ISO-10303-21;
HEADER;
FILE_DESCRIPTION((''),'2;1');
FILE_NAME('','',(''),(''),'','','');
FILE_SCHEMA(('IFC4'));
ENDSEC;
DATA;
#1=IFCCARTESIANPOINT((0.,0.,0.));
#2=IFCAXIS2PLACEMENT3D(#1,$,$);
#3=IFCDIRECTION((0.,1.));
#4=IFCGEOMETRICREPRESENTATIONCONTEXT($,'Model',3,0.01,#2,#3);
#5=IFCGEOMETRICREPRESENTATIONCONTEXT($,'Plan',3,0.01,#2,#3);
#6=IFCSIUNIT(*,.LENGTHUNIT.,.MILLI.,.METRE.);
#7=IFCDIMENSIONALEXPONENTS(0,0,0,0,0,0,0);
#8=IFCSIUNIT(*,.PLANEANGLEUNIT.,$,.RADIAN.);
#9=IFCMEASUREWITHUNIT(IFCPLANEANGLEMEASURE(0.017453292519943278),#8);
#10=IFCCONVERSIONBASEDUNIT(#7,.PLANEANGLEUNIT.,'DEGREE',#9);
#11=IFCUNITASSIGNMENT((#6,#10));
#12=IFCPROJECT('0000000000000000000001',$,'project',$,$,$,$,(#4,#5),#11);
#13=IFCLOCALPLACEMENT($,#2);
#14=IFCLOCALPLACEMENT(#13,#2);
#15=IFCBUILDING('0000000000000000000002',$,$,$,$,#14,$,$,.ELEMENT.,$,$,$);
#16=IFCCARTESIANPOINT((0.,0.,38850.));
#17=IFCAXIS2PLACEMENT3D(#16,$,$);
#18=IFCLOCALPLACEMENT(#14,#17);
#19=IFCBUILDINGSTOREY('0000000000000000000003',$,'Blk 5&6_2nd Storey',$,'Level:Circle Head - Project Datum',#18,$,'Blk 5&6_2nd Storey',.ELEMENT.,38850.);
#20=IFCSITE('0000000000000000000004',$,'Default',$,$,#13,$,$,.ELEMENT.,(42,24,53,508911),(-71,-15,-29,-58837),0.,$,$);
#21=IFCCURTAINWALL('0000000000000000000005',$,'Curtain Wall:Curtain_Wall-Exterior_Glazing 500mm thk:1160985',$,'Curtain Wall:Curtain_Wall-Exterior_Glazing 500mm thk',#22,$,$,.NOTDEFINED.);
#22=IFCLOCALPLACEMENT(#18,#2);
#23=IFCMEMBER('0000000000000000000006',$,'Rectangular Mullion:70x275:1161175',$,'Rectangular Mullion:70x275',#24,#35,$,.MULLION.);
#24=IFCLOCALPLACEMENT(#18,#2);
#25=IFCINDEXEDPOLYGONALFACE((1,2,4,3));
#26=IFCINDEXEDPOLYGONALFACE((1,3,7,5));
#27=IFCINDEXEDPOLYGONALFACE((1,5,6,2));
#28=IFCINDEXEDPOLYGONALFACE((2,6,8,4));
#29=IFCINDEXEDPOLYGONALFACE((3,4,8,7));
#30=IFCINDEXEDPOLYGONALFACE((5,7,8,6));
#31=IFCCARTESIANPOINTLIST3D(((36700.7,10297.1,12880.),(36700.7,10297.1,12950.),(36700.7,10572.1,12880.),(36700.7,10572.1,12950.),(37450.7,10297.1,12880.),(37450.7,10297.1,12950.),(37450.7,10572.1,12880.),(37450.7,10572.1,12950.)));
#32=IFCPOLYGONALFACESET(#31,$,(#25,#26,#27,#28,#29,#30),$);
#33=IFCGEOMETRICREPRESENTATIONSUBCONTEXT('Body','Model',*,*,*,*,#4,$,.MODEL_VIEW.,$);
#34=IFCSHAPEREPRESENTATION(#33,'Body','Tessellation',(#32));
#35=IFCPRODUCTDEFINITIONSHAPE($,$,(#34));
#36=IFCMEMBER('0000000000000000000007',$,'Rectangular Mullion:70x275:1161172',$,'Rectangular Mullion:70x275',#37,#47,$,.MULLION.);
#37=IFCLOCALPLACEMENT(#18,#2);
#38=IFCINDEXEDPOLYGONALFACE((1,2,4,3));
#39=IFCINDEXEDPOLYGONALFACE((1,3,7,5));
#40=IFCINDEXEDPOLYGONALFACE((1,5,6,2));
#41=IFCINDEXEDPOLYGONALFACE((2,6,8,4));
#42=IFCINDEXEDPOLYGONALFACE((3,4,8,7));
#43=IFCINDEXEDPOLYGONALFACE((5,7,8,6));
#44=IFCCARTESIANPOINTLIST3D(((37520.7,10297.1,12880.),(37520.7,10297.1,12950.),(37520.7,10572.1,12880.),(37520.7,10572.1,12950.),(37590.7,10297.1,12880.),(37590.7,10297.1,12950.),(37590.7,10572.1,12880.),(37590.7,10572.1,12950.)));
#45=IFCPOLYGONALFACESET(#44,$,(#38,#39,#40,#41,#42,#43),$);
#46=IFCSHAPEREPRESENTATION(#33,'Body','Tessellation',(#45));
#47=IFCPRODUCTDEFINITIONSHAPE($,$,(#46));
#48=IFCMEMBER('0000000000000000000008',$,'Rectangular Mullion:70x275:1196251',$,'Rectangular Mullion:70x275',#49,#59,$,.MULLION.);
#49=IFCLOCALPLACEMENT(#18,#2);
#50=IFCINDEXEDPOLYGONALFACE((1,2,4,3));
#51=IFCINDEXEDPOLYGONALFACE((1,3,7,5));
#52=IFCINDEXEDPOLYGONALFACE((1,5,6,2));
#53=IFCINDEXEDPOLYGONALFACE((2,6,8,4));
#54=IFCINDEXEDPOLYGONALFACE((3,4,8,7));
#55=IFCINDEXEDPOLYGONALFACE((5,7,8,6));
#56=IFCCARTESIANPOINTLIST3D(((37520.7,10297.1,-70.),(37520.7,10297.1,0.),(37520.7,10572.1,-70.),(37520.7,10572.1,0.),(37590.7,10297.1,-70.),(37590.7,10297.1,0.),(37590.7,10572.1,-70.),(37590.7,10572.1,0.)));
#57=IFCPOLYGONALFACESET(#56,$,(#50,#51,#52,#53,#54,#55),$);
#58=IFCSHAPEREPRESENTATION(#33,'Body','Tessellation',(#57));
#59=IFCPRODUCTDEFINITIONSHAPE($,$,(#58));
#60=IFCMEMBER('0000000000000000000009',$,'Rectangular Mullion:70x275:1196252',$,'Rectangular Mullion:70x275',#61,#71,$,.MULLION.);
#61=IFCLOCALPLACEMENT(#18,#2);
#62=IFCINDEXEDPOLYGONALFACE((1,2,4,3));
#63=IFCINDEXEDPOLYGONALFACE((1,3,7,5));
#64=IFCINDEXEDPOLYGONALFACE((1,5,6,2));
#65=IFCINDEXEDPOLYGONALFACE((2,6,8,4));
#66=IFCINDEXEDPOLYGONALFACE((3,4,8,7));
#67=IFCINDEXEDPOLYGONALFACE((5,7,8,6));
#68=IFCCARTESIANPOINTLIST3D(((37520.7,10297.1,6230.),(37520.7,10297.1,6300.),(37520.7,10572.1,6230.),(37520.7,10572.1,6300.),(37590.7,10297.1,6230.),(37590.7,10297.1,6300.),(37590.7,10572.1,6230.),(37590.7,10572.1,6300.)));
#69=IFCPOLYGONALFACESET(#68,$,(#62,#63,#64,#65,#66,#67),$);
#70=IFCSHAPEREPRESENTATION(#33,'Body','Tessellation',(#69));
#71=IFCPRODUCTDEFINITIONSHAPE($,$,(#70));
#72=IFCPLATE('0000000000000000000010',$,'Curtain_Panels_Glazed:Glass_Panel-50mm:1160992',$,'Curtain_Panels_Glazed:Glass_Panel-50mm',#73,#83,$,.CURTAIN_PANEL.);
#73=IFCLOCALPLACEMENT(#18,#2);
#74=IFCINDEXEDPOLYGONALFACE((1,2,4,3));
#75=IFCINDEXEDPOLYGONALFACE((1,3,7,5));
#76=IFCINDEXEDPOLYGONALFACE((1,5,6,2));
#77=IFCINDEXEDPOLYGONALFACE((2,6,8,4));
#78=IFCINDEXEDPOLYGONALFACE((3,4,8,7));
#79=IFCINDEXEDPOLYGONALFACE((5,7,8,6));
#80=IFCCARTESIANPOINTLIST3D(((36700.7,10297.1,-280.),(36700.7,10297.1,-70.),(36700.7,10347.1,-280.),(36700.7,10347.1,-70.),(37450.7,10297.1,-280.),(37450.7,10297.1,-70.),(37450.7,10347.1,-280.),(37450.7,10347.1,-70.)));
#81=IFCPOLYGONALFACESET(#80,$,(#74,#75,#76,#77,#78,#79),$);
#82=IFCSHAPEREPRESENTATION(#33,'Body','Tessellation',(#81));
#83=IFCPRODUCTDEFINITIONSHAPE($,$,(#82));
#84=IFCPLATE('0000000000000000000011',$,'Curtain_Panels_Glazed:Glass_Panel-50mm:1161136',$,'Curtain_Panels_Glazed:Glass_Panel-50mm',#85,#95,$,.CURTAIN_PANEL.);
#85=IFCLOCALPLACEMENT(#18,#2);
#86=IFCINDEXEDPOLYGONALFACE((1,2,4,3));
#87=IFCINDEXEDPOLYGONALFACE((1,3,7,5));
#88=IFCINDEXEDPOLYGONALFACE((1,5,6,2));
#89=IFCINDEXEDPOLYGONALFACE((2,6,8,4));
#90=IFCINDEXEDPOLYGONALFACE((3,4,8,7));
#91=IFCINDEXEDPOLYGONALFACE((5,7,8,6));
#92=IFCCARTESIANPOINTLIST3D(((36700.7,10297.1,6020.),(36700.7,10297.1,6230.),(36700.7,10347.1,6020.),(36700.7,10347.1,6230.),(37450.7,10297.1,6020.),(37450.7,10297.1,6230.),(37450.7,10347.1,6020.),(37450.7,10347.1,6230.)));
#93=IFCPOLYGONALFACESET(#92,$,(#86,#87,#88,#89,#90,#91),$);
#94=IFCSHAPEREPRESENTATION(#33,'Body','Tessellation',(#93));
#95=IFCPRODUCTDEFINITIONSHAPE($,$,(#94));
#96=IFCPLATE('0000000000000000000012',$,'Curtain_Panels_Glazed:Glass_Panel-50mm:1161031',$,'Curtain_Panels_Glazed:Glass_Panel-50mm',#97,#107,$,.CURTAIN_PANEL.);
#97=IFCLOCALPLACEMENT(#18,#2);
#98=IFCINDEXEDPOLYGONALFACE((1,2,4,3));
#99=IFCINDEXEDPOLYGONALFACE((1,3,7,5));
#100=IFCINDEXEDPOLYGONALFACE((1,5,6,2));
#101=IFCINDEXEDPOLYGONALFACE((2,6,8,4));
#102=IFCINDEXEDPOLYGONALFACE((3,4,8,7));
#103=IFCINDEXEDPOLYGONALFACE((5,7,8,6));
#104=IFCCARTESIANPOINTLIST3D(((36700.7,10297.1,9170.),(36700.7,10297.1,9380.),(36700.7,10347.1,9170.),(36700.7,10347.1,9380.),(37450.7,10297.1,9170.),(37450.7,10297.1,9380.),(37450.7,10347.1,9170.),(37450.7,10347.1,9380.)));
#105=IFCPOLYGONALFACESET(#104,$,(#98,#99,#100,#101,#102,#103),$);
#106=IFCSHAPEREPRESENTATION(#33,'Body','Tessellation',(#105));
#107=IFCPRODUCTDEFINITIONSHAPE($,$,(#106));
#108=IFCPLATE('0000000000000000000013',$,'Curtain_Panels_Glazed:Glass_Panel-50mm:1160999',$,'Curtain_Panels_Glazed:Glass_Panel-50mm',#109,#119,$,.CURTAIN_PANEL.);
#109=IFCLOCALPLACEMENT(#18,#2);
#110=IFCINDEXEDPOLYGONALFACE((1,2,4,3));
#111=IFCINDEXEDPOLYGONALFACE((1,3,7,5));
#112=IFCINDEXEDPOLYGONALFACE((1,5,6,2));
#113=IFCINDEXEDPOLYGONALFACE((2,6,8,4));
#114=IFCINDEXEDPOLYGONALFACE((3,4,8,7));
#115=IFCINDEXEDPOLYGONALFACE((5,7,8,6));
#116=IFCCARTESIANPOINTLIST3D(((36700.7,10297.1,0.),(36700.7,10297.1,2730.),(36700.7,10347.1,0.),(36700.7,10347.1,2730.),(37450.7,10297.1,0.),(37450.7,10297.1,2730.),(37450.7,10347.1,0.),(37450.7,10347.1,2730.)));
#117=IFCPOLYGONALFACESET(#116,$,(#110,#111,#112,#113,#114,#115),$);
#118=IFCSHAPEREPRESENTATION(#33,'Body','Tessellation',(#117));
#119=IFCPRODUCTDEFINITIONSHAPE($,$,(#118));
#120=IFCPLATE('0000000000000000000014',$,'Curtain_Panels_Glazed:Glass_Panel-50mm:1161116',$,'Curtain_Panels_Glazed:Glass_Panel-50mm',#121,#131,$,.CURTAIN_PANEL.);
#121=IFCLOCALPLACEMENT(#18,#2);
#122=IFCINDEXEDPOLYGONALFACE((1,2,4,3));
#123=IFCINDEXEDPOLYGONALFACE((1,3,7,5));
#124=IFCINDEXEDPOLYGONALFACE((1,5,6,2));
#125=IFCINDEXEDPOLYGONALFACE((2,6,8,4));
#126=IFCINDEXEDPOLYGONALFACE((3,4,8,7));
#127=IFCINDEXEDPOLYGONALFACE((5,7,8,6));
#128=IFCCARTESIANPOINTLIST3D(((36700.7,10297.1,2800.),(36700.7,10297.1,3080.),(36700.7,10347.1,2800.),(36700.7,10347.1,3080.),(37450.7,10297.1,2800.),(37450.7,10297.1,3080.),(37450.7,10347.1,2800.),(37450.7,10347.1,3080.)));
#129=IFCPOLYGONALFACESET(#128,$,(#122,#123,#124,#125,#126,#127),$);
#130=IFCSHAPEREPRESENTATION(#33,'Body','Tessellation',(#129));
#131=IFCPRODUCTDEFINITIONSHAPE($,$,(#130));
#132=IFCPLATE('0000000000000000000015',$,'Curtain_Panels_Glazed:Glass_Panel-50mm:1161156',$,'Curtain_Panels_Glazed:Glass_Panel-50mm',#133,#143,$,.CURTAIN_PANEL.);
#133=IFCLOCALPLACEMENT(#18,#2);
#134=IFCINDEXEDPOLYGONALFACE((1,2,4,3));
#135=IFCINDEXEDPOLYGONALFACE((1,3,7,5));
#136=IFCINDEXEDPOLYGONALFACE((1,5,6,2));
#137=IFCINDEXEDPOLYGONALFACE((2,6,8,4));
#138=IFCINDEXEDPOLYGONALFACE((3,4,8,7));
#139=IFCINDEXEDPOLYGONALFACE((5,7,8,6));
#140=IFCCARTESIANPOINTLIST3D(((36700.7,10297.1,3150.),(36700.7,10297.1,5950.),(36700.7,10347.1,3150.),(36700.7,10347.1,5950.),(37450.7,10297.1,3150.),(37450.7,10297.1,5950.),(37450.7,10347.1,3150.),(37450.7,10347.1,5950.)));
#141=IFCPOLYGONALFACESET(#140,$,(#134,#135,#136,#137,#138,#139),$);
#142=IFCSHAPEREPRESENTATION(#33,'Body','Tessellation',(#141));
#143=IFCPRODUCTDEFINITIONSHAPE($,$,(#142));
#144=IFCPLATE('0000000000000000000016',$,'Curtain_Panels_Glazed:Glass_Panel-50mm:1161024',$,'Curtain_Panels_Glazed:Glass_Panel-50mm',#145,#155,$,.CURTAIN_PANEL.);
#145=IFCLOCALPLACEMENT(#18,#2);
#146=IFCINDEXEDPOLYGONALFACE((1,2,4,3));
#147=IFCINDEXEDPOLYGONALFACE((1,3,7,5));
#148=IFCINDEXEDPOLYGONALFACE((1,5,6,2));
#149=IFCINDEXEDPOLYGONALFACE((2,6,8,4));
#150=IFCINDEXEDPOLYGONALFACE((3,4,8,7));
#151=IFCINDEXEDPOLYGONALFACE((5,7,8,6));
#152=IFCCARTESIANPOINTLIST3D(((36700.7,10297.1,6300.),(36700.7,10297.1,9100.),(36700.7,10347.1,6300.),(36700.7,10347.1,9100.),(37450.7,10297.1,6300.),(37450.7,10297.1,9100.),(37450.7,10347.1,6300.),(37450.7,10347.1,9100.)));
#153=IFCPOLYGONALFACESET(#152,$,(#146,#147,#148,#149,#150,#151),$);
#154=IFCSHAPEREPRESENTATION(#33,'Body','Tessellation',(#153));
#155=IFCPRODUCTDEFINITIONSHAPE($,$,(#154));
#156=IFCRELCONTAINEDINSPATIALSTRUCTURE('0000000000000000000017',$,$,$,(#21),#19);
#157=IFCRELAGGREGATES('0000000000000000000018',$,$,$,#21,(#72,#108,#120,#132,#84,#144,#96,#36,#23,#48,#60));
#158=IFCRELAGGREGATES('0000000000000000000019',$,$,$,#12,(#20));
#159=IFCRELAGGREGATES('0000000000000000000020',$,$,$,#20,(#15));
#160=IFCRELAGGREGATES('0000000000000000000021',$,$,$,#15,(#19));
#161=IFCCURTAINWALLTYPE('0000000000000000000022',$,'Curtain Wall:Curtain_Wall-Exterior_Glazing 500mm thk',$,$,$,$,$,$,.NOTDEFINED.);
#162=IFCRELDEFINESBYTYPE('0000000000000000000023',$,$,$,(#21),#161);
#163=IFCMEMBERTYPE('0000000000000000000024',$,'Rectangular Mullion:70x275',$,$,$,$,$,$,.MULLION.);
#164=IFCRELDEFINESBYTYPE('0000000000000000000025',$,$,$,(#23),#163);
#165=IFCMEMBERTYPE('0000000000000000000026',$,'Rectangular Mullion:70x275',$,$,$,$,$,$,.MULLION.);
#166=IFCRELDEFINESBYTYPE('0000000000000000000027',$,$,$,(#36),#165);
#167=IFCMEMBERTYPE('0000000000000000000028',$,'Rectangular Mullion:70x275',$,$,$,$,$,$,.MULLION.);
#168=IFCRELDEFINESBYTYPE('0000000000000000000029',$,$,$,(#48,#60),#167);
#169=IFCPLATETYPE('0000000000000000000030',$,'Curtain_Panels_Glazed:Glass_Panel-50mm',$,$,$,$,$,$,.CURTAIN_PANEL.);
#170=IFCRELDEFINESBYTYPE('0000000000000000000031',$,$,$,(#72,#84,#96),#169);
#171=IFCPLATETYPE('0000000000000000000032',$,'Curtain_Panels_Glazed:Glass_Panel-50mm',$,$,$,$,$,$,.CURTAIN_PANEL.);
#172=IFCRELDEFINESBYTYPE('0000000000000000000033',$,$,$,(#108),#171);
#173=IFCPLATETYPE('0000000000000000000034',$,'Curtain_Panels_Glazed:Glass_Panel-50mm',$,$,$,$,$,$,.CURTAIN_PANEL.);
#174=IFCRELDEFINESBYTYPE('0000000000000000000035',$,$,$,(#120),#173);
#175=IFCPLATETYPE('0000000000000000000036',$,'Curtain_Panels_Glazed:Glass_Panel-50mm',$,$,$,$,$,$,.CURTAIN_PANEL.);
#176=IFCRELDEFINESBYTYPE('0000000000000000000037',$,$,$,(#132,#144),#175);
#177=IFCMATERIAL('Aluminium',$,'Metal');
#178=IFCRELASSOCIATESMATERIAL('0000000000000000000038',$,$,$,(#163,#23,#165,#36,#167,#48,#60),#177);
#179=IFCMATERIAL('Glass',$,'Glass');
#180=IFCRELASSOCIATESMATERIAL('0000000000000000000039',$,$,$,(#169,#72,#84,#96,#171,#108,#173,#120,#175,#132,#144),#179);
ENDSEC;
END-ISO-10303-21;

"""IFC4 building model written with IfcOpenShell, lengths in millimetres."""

from ifc_helpers import new_model, entity, si_unit, converted_unit, direction, frame, origin, place, context, subcontext, project, spatial, indexed_curve, outline, extrude, source, transform, mapped, material, type_object, type_shapes, element, aggregate, save


model = new_model("IFC4")

# Units and contexts
model_context = context("Model", 3, precision=0.01, world=origin(), true_north=direction((0.0, 1.0)))
plan_context = context("Plan", 3, precision=0.01, world=origin(), true_north=direction((0.0, 1.0)))
body_context = subcontext(model_context, "Body", "Model", "MODEL_VIEW")
ifc_project = project(units=[si_unit("LENGTHUNIT", "METRE", prefix="MILLI"), converted_unit("PLANEANGLEUNIT", "DEGREE", entity("IfcPlaneAngleMeasure", 0.017453292519943278), si_unit("PLANEANGLEUNIT", "RADIAN"), dimensions=[0, 0, 0, 0, 0, 0, 0])], contexts=[model_context, plan_context])

# Site, building, storey
site_placement = place(None, origin())
site = spatial("IfcSite", under=ifc_project, at=site_placement, Name="Default", CompositionType="ELEMENT", RefLatitude=(42, 24, 53, 508911), RefLongitude=(-71, -15, -29, -58837), RefElevation=0.0)
building_placement = place(site_placement, origin())
building = spatial("IfcBuilding", under=site, at=building_placement, CompositionType="ELEMENT")
storey_placement = place(building_placement, frame((0.0, 0.0, 38850.0)))
storey = spatial("IfcBuildingStorey", under=building, at=storey_placement, Name="Blk 5&6_2nd Storey", ObjectType="Level:Circle Head - Project Datum", LongName="Blk 5&6_2nd Storey", CompositionType="ELEMENT", Elevation=38850.0)

# Curtain wall, members, plates
curtain_wall_type = type_object("IfcCurtainWallType", Name="Curtain Wall:Curtain_Wall-Exterior_Glazing 500mm thk", PredefinedType="NOTDEFINED")
curtain_wall_placement = place(storey_placement, frame((0.0, 0.0, -38850.0)))
curtain_wall = element("IfcCurtainWall", 1, at=curtain_wall_placement, inside=storey, type_object=curtain_wall_type, Name="Curtain Wall:Curtain_Wall-Exterior_Glazing 500mm thk:1160985", ObjectType="Curtain Wall:Curtain_Wall-Exterior_Glazing 500mm thk", PredefinedType="NOTDEFINED")
ifc_material_1 = material(Name="Aluminium", Category="Metal")
member_type_1 = type_object("IfcMemberType", Name="Rectangular Mullion:70x275", PredefinedType="MULLION", material=ifc_material_1)
shared_shape_1 = source(origin(), body_context, "Body", "SweptSolid", [
    extrude(outline(indexed_curve([(-35.0, -137.5), (35.0, -137.5), (35.0, 137.5), (-35.0, 137.5), (-35.0, -137.5)], self_intersect=False)), frame((-35.0, -137.5, -750.0), z_axis=(0.0, 0.0, 1.0), x_axis=(-1.0, 0.0, 0.0)), (0.0, 0.0, 1.0), 750.0),
])
type_shapes(member_type_1, [shared_shape_1])
member_1_placement = place(curtain_wall_placement, frame((36700.7, 10572.1, 51800.0), z_axis=(-1.0, 0.0, 0.0), x_axis=(0.0, 0.0, 1.0)))
member_1 = element("IfcMember", 2, at=member_1_placement, type_object=member_type_1, material=ifc_material_1, Name="Rectangular Mullion:70x275:1161175", ObjectType="Rectangular Mullion:70x275", PredefinedType="MULLION", context=body_context, shape_type="MappedRepresentation", body=[
    mapped(shared_shape_1, transform((0.0, 0.0, 0.0), scale=1.0)),
])
member_type_2 = type_object("IfcMemberType", Name="Rectangular Mullion:70x275", PredefinedType="MULLION", material=ifc_material_1)
shared_shape_2 = source(origin(), body_context, "Body", "SweptSolid", [
    extrude(outline(indexed_curve([(-35.0, -137.5), (35.0, -137.5), (35.0, 137.5), (-35.0, 137.5), (-35.0, -137.5)], self_intersect=False)), frame((-35.0, -137.5, -70.0), z_axis=(0.0, 0.0, 1.0), x_axis=(-1.0, 0.0, 0.0)), (0.0, 0.0, 1.0), 70.0),
])
type_shapes(member_type_2, [shared_shape_2])
member_2_placement = place(curtain_wall_placement, frame((37520.7, 10572.1, 51800.0), z_axis=(-1.0, 0.0, 0.0), x_axis=(0.0, 0.0, 1.0)))
member_2 = element("IfcMember", 3, at=member_2_placement, type_object=member_type_2, material=ifc_material_1, Name="Rectangular Mullion:70x275:1161172", ObjectType="Rectangular Mullion:70x275", PredefinedType="MULLION", context=body_context, shape_type="MappedRepresentation", body=[
    mapped(shared_shape_2, transform((0.0, 0.0, 0.0), scale=1.0)),
])
member_type_3 = type_object("IfcMemberType", Name="Rectangular Mullion:70x275", PredefinedType="MULLION", material=ifc_material_1)
shared_shape_3 = source(origin(), body_context, "Body", "SweptSolid", [
    extrude(outline(indexed_curve([(-35.0, -137.5), (35.0, -137.5), (35.0, 137.5), (-35.0, 137.5), (-35.0, -137.5)], self_intersect=False)), frame((0.0, -137.5, -70.0), z_axis=(0.0, 0.0, 1.0), x_axis=(-1.0, 0.0, 0.0)), (0.0, 0.0, 1.0), 70.0),
])
type_shapes(member_type_3, [shared_shape_3])
member_3_placement = place(curtain_wall_placement, frame((37520.7, 10572.1, 38815.0), z_axis=(-1.0, 0.0, 0.0), x_axis=(0.0, 0.0, 1.0)))
member_3 = element("IfcMember", 4, at=member_3_placement, type_object=member_type_3, material=ifc_material_1, Name="Rectangular Mullion:70x275:1196251", ObjectType="Rectangular Mullion:70x275", PredefinedType="MULLION", context=body_context, shape_type="MappedRepresentation", body=[
    mapped(shared_shape_3, transform((0.0, 0.0, 0.0), scale=1.0)),
])
member_4_placement = place(curtain_wall_placement, frame((37520.7, 10572.1, 45115.0), z_axis=(-1.0, 0.0, 0.0), x_axis=(0.0, 0.0, 1.0)))
member_4 = element("IfcMember", 5, at=member_4_placement, type_object=member_type_3, material=ifc_material_1, Name="Rectangular Mullion:70x275:1196252", ObjectType="Rectangular Mullion:70x275", PredefinedType="MULLION", context=body_context, shape_type="MappedRepresentation", body=[
    mapped(shared_shape_3, transform((0.0, 0.0, 0.0), scale=1.0)),
])
ifc_material_2 = material(Name="Glass", Category="Glass")
plate_type_1 = type_object("IfcPlateType", Name="Curtain_Panels_Glazed:Glass_Panel-50mm", PredefinedType="CURTAIN_PANEL", material=ifc_material_2)
shared_shape_4 = source(origin(), body_context, "Body", "SweptSolid", [
    extrude(outline(indexed_curve([(-25.0, -375.0), (25.0, -375.0), (25.0, 375.0), (-25.0, 375.0), (-25.0, -375.0)], self_intersect=False)), frame((0.0, 250.0, 0.0), z_axis=(0.0, 0.0, 1.0), x_axis=(0.0, 1.0, 0.0)), (0.0, 0.0, 1.0), 210.0),
])
type_shapes(plate_type_1, [shared_shape_4])
plate_1_placement = place(curtain_wall_placement, frame((37075.7, 10572.1, 38570.0), z_axis=(0.0, 0.0, 1.0), x_axis=(-1.0, 0.0, 0.0)))
plate_1 = element("IfcPlate", 6, at=plate_1_placement, type_object=plate_type_1, material=ifc_material_2, Name="Curtain_Panels_Glazed:Glass_Panel-50mm:1160992", ObjectType="Curtain_Panels_Glazed:Glass_Panel-50mm", PredefinedType="CURTAIN_PANEL", context=body_context, shape_type="MappedRepresentation", body=[
    mapped(shared_shape_4, transform((0.0, 0.0, 0.0), scale=1.0)),
])
plate_2_placement = place(curtain_wall_placement, frame((37075.7, 10572.1, 44870.0), z_axis=(0.0, 0.0, 1.0), x_axis=(-1.0, 0.0, 0.0)))
plate_2 = element("IfcPlate", 7, at=plate_2_placement, type_object=plate_type_1, material=ifc_material_2, Name="Curtain_Panels_Glazed:Glass_Panel-50mm:1161136", ObjectType="Curtain_Panels_Glazed:Glass_Panel-50mm", PredefinedType="CURTAIN_PANEL", context=body_context, shape_type="MappedRepresentation", body=[
    mapped(shared_shape_4, transform((0.0, 0.0, 0.0), scale=1.0)),
])
plate_3_placement = place(curtain_wall_placement, frame((37075.7, 10572.1, 48020.0), z_axis=(0.0, 0.0, 1.0), x_axis=(-1.0, 0.0, 0.0)))
plate_3 = element("IfcPlate", 8, at=plate_3_placement, type_object=plate_type_1, material=ifc_material_2, Name="Curtain_Panels_Glazed:Glass_Panel-50mm:1161031", ObjectType="Curtain_Panels_Glazed:Glass_Panel-50mm", PredefinedType="CURTAIN_PANEL", context=body_context, shape_type="MappedRepresentation", body=[
    mapped(shared_shape_4, transform((0.0, 0.0, 0.0), scale=1.0)),
])
plate_type_2 = type_object("IfcPlateType", Name="Curtain_Panels_Glazed:Glass_Panel-50mm", PredefinedType="CURTAIN_PANEL", material=ifc_material_2)
shared_shape_5 = source(origin(), body_context, "Body", "SweptSolid", [
    extrude(outline(indexed_curve([(-25.0, -375.0), (25.0, -375.0), (25.0, 375.0), (-25.0, 375.0), (-25.0, -375.0)], self_intersect=False)), frame((0.0, 250.0, 0.0), z_axis=(0.0, 0.0, 1.0), x_axis=(0.0, 1.0, 0.0)), (0.0, 0.0, 1.0), 2730.0),
])
type_shapes(plate_type_2, [shared_shape_5])
plate_4_placement = place(curtain_wall_placement, frame((37075.7, 10572.1, 38850.0), z_axis=(0.0, 0.0, 1.0), x_axis=(-1.0, 0.0, 0.0)))
plate_4 = element("IfcPlate", 9, at=plate_4_placement, type_object=plate_type_2, material=ifc_material_2, Name="Curtain_Panels_Glazed:Glass_Panel-50mm:1160999", ObjectType="Curtain_Panels_Glazed:Glass_Panel-50mm", PredefinedType="CURTAIN_PANEL", context=body_context, shape_type="MappedRepresentation", body=[
    mapped(shared_shape_5, transform((0.0, 0.0, 0.0), scale=1.0)),
])
plate_type_3 = type_object("IfcPlateType", Name="Curtain_Panels_Glazed:Glass_Panel-50mm", PredefinedType="CURTAIN_PANEL", material=ifc_material_2)
shared_shape_6 = source(origin(), body_context, "Body", "SweptSolid", [
    extrude(outline(indexed_curve([(-25.0, -375.0), (25.0, -375.0), (25.0, 375.0), (-25.0, 375.0), (-25.0, -375.0)], self_intersect=False)), frame((0.0, 250.0, 0.0), z_axis=(0.0, 0.0, 1.0), x_axis=(0.0, 1.0, 0.0)), (0.0, 0.0, 1.0), 280.0),
])
type_shapes(plate_type_3, [shared_shape_6])
plate_5_placement = place(curtain_wall_placement, frame((37075.7, 10572.1, 41650.0), z_axis=(0.0, 0.0, 1.0), x_axis=(-1.0, 0.0, 0.0)))
plate_5 = element("IfcPlate", 10, at=plate_5_placement, type_object=plate_type_3, material=ifc_material_2, Name="Curtain_Panels_Glazed:Glass_Panel-50mm:1161116", ObjectType="Curtain_Panels_Glazed:Glass_Panel-50mm", PredefinedType="CURTAIN_PANEL", context=body_context, shape_type="MappedRepresentation", body=[
    mapped(shared_shape_6, transform((0.0, 0.0, 0.0), scale=1.0)),
])
plate_type_4 = type_object("IfcPlateType", Name="Curtain_Panels_Glazed:Glass_Panel-50mm", PredefinedType="CURTAIN_PANEL", material=ifc_material_2)
shared_shape_7 = source(origin(), body_context, "Body", "SweptSolid", [
    extrude(outline(indexed_curve([(-25.0, -375.0), (25.0, -375.0), (25.0, 375.0), (-25.0, 375.0), (-25.0, -375.0)], self_intersect=False)), frame((0.0, 250.0, 0.0), z_axis=(0.0, 0.0, 1.0), x_axis=(0.0, 1.0, 0.0)), (0.0, 0.0, 1.0), 2800.0),
])
type_shapes(plate_type_4, [shared_shape_7])
plate_6_placement = place(curtain_wall_placement, frame((37075.7, 10572.1, 42000.0), z_axis=(0.0, 0.0, 1.0), x_axis=(-1.0, 0.0, 0.0)))
plate_6 = element("IfcPlate", 11, at=plate_6_placement, type_object=plate_type_4, material=ifc_material_2, Name="Curtain_Panels_Glazed:Glass_Panel-50mm:1161156", ObjectType="Curtain_Panels_Glazed:Glass_Panel-50mm", PredefinedType="CURTAIN_PANEL", context=body_context, shape_type="MappedRepresentation", body=[
    mapped(shared_shape_7, transform((0.0, 0.0, 0.0), scale=1.0)),
])
plate_7_placement = place(curtain_wall_placement, frame((37075.7, 10572.1, 45150.0), z_axis=(0.0, 0.0, 1.0), x_axis=(-1.0, 0.0, 0.0)))
plate_7 = element("IfcPlate", 12, at=plate_7_placement, type_object=plate_type_4, material=ifc_material_2, Name="Curtain_Panels_Glazed:Glass_Panel-50mm:1161024", ObjectType="Curtain_Panels_Glazed:Glass_Panel-50mm", PredefinedType="CURTAIN_PANEL", context=body_context, shape_type="MappedRepresentation", body=[
    mapped(shared_shape_7, transform((0.0, 0.0, 0.0), scale=1.0)),
])
aggregate(curtain_wall, [plate_1, plate_4, plate_5, plate_6, plate_2, plate_7, plate_3, member_2, member_1, member_3, member_4])

save(model, "model.ifc")
